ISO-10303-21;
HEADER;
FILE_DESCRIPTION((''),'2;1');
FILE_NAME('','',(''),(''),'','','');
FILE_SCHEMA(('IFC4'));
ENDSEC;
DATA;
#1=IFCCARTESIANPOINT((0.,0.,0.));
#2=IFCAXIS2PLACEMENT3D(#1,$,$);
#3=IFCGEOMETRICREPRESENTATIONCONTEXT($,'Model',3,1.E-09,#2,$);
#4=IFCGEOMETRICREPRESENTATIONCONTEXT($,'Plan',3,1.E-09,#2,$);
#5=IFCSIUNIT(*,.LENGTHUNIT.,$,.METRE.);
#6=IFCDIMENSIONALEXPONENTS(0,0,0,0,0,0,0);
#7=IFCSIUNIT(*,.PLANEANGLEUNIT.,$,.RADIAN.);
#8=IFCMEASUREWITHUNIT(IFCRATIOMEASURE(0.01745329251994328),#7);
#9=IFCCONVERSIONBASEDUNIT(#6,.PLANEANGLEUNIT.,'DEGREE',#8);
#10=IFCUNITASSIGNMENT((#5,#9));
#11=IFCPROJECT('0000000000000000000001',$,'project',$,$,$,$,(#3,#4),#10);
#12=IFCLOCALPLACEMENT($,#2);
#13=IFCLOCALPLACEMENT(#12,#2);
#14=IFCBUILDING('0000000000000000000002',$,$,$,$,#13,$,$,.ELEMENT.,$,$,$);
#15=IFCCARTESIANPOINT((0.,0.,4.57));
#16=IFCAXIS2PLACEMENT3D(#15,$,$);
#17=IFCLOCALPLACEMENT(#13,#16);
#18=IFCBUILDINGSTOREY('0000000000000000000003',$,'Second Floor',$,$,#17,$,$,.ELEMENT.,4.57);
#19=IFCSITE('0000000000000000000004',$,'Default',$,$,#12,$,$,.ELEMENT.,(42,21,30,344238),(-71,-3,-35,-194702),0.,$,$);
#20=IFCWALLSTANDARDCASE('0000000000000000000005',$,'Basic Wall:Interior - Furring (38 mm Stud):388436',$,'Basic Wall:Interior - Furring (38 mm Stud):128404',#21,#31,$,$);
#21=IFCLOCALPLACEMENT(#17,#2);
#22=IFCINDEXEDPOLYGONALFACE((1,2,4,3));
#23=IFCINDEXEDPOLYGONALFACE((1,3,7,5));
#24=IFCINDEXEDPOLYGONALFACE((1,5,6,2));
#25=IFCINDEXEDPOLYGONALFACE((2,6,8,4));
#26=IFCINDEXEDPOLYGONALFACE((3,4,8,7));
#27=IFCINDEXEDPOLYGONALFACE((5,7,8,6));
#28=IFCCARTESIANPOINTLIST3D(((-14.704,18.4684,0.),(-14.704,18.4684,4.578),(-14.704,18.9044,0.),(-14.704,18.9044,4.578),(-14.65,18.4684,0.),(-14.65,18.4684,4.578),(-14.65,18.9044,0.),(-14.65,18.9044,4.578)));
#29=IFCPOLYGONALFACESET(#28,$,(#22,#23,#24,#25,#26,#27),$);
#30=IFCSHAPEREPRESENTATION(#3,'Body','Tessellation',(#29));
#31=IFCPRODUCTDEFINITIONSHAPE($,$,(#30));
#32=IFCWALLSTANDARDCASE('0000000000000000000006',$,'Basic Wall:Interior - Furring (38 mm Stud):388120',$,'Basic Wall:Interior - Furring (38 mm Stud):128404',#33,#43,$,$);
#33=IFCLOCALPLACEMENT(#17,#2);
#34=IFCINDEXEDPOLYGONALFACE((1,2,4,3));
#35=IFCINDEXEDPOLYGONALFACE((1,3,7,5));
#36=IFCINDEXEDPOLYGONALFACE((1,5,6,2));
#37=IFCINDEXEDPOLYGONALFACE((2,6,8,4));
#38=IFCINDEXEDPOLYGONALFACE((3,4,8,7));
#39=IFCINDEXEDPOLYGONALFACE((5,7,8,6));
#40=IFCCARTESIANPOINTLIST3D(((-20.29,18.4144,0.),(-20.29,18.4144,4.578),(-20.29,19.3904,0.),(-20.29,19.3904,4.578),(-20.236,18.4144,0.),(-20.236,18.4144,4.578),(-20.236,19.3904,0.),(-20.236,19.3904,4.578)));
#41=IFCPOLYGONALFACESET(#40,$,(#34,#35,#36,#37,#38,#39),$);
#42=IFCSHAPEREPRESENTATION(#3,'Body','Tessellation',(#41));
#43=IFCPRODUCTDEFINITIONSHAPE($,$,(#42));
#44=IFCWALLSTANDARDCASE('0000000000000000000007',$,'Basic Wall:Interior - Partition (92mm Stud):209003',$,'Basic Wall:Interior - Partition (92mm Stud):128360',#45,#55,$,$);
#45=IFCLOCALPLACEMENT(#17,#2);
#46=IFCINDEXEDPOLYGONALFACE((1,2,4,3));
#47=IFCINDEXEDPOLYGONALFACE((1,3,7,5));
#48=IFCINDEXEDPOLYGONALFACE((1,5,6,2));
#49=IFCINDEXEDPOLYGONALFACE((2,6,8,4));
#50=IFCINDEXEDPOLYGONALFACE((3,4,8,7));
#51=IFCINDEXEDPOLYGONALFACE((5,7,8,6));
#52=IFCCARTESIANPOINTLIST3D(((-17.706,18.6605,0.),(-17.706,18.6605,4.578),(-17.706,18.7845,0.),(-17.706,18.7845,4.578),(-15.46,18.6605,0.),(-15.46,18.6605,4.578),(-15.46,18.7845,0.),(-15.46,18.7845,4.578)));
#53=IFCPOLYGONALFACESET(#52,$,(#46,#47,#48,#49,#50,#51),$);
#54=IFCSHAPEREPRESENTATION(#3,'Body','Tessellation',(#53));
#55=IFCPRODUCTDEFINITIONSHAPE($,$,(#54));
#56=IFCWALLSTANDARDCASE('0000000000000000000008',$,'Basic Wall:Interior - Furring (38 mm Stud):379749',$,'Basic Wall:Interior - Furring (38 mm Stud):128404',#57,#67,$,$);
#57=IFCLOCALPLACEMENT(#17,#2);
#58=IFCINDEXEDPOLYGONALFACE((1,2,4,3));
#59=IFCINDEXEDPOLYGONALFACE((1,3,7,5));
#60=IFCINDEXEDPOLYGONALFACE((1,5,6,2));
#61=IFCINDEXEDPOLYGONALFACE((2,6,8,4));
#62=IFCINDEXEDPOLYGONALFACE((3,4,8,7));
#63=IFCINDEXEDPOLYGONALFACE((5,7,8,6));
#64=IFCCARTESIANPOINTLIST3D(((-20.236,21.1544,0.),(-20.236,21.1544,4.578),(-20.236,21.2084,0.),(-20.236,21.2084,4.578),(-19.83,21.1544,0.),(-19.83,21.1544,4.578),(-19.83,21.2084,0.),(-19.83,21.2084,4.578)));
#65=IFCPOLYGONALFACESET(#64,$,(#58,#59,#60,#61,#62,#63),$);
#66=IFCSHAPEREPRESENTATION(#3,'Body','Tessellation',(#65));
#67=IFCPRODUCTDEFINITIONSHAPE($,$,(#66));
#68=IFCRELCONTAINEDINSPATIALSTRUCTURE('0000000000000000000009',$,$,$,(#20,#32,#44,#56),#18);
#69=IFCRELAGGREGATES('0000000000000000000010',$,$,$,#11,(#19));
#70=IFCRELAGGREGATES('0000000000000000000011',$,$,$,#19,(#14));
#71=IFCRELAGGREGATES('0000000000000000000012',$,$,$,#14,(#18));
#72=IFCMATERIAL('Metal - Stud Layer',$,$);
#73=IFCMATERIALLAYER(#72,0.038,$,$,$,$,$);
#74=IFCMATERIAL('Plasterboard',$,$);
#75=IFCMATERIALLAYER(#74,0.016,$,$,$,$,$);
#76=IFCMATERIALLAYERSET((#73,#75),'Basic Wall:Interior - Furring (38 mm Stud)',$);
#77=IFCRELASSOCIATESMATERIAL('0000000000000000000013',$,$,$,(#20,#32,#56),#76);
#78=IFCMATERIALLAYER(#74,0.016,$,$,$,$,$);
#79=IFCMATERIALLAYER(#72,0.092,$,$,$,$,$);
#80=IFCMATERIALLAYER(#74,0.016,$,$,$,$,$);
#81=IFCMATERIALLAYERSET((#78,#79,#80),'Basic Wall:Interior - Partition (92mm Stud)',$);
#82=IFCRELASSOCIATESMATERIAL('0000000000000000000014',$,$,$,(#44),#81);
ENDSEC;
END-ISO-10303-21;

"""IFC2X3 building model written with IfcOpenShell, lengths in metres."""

from ifc_helpers import new_model, entity, si_unit, converted_unit, frame, frame_2d, origin, place, context, project, spatial, rectangle, extrude, material, layer, layer_set, layer_usage, element, save


model = new_model("IFC2X3")

# Units and contexts
model_context = context("Model", 3, precision=1e-09, world=origin())
plan_context = context("Plan", 3, precision=1e-09, world=origin())
ifc_project = project(units=[si_unit("LENGTHUNIT", "METRE"), converted_unit("PLANEANGLEUNIT", "DEGREE", entity("IfcRatioMeasure", 0.01745329251994328), si_unit("PLANEANGLEUNIT", "RADIAN"), dimensions=[0, 0, 0, 0, 0, 0, 0])], contexts=[model_context, plan_context])

# Site, building, storey
site_placement = place(None, origin())
site = spatial("IfcSite", under=ifc_project, at=site_placement, Name="Default", CompositionType="ELEMENT", RefLatitude=(42, 21, 30, 344238), RefLongitude=(-71, -3, -35, -194702), RefElevation=0.0)
building_placement = place(site_placement, origin())
building = spatial("IfcBuilding", under=site, at=building_placement, CompositionType="ELEMENT")
storey_placement = place(building_placement, frame((0.0, 0.0, 4.57)))
storey = spatial("IfcBuildingStorey", under=building, at=storey_placement, Name="Second Floor", CompositionType="ELEMENT", Elevation=4.57)

# Shared definitions
ifc_material_1 = material(Name="Plasterboard")
ifc_layer_1 = layer(ifc_material_1, 0.016)
ifc_material_2 = material(Name="Metal - Stud Layer")
ifc_layer_2 = layer(ifc_material_2, 0.092)
ifc_layer_3 = layer(ifc_material_1, 0.016)
ifc_layer_set_1 = layer_set([ifc_layer_1, ifc_layer_2, ifc_layer_3], Name="Basic Wall:Interior - Partition (92mm Stud)")
ifc_layer_usage_1 = layer_usage(ifc_layer_set_1, "AXIS2", "NEGATIVE", 0.062)

# Shared definitions
ifc_layer_4 = layer(ifc_material_2, 0.038)
ifc_layer_5 = layer(ifc_material_1, 0.016)
ifc_layer_set_2 = layer_set([ifc_layer_4, ifc_layer_5], Name="Basic Wall:Interior - Furring (38 mm Stud)")
ifc_layer_usage_2 = layer_usage(ifc_layer_set_2, "AXIS2", "POSITIVE", -0.027)

# Walls
ifc_layer_usage_3 = layer_usage(ifc_layer_set_2, "AXIS2", "NEGATIVE", 0.027)
wall_1_placement = place(storey_placement, frame((-14.677, 18.9044, 0.0), z_axis=(0.0, 0.0, 1.0), x_axis=(0.0, -1.0, 0.0)))
element("IfcWallStandardCase", 1, at=wall_1_placement, inside=storey, material=ifc_layer_usage_2, Name="Basic Wall:Interior - Furring (38 mm Stud):388436", ObjectType="Basic Wall:Interior - Furring (38 mm Stud):128404", context=model_context, shape_type="SweptSolid", body=[
    extrude(rectangle(XDim=0.436, YDim=0.054, at=frame_2d((0.218, 0.0), x_axis=(-1.0, 0.0))), origin(), (0.0, 0.0, 1.0), 4.578),
])
wall_2_placement = place(storey_placement, frame((-20.263, 18.4144, 0.0), z_axis=(0.0, 0.0, 1.0), x_axis=(0.0, 1.0, 0.0)))
element("IfcWallStandardCase", 2, at=wall_2_placement, inside=storey, material=ifc_layer_usage_2, Name="Basic Wall:Interior - Furring (38 mm Stud):388120", ObjectType="Basic Wall:Interior - Furring (38 mm Stud):128404", context=model_context, shape_type="SweptSolid", body=[
    extrude(rectangle(XDim=0.976, YDim=0.054, at=frame_2d((0.488, 0.0), x_axis=(-1.0, 0.0))), origin(), (0.0, 0.0, 1.0), 4.578),
])
wall_3_placement = place(storey_placement, frame((-17.706, 18.7225, 0.0)))
element("IfcWallStandardCase", 3, at=wall_3_placement, inside=storey, material=ifc_layer_usage_1, Name="Basic Wall:Interior - Partition (92mm Stud):209003", ObjectType="Basic Wall:Interior - Partition (92mm Stud):128360", context=model_context, shape_type="SweptSolid", body=[
    extrude(rectangle(XDim=2.246, YDim=0.124, at=frame_2d((1.123, 0.0), x_axis=(-1.0, 0.0))), origin(), (0.0, 0.0, 1.0), 4.578),
])
wall_4_placement = place(storey_placement, frame((-20.236, 21.1814, 0.0)))
element("IfcWallStandardCase", 4, at=wall_4_placement, inside=storey, material=ifc_layer_usage_3, Name="Basic Wall:Interior - Furring (38 mm Stud):379749", ObjectType="Basic Wall:Interior - Furring (38 mm Stud):128404", context=model_context, shape_type="SweptSolid", body=[
    extrude(rectangle(XDim=0.406, YDim=0.054, at=frame_2d((0.203, 0.0), x_axis=(-1.0, 0.0))), origin(), (0.0, 0.0, 1.0), 4.578),
])

save(model, "model.ifc")
